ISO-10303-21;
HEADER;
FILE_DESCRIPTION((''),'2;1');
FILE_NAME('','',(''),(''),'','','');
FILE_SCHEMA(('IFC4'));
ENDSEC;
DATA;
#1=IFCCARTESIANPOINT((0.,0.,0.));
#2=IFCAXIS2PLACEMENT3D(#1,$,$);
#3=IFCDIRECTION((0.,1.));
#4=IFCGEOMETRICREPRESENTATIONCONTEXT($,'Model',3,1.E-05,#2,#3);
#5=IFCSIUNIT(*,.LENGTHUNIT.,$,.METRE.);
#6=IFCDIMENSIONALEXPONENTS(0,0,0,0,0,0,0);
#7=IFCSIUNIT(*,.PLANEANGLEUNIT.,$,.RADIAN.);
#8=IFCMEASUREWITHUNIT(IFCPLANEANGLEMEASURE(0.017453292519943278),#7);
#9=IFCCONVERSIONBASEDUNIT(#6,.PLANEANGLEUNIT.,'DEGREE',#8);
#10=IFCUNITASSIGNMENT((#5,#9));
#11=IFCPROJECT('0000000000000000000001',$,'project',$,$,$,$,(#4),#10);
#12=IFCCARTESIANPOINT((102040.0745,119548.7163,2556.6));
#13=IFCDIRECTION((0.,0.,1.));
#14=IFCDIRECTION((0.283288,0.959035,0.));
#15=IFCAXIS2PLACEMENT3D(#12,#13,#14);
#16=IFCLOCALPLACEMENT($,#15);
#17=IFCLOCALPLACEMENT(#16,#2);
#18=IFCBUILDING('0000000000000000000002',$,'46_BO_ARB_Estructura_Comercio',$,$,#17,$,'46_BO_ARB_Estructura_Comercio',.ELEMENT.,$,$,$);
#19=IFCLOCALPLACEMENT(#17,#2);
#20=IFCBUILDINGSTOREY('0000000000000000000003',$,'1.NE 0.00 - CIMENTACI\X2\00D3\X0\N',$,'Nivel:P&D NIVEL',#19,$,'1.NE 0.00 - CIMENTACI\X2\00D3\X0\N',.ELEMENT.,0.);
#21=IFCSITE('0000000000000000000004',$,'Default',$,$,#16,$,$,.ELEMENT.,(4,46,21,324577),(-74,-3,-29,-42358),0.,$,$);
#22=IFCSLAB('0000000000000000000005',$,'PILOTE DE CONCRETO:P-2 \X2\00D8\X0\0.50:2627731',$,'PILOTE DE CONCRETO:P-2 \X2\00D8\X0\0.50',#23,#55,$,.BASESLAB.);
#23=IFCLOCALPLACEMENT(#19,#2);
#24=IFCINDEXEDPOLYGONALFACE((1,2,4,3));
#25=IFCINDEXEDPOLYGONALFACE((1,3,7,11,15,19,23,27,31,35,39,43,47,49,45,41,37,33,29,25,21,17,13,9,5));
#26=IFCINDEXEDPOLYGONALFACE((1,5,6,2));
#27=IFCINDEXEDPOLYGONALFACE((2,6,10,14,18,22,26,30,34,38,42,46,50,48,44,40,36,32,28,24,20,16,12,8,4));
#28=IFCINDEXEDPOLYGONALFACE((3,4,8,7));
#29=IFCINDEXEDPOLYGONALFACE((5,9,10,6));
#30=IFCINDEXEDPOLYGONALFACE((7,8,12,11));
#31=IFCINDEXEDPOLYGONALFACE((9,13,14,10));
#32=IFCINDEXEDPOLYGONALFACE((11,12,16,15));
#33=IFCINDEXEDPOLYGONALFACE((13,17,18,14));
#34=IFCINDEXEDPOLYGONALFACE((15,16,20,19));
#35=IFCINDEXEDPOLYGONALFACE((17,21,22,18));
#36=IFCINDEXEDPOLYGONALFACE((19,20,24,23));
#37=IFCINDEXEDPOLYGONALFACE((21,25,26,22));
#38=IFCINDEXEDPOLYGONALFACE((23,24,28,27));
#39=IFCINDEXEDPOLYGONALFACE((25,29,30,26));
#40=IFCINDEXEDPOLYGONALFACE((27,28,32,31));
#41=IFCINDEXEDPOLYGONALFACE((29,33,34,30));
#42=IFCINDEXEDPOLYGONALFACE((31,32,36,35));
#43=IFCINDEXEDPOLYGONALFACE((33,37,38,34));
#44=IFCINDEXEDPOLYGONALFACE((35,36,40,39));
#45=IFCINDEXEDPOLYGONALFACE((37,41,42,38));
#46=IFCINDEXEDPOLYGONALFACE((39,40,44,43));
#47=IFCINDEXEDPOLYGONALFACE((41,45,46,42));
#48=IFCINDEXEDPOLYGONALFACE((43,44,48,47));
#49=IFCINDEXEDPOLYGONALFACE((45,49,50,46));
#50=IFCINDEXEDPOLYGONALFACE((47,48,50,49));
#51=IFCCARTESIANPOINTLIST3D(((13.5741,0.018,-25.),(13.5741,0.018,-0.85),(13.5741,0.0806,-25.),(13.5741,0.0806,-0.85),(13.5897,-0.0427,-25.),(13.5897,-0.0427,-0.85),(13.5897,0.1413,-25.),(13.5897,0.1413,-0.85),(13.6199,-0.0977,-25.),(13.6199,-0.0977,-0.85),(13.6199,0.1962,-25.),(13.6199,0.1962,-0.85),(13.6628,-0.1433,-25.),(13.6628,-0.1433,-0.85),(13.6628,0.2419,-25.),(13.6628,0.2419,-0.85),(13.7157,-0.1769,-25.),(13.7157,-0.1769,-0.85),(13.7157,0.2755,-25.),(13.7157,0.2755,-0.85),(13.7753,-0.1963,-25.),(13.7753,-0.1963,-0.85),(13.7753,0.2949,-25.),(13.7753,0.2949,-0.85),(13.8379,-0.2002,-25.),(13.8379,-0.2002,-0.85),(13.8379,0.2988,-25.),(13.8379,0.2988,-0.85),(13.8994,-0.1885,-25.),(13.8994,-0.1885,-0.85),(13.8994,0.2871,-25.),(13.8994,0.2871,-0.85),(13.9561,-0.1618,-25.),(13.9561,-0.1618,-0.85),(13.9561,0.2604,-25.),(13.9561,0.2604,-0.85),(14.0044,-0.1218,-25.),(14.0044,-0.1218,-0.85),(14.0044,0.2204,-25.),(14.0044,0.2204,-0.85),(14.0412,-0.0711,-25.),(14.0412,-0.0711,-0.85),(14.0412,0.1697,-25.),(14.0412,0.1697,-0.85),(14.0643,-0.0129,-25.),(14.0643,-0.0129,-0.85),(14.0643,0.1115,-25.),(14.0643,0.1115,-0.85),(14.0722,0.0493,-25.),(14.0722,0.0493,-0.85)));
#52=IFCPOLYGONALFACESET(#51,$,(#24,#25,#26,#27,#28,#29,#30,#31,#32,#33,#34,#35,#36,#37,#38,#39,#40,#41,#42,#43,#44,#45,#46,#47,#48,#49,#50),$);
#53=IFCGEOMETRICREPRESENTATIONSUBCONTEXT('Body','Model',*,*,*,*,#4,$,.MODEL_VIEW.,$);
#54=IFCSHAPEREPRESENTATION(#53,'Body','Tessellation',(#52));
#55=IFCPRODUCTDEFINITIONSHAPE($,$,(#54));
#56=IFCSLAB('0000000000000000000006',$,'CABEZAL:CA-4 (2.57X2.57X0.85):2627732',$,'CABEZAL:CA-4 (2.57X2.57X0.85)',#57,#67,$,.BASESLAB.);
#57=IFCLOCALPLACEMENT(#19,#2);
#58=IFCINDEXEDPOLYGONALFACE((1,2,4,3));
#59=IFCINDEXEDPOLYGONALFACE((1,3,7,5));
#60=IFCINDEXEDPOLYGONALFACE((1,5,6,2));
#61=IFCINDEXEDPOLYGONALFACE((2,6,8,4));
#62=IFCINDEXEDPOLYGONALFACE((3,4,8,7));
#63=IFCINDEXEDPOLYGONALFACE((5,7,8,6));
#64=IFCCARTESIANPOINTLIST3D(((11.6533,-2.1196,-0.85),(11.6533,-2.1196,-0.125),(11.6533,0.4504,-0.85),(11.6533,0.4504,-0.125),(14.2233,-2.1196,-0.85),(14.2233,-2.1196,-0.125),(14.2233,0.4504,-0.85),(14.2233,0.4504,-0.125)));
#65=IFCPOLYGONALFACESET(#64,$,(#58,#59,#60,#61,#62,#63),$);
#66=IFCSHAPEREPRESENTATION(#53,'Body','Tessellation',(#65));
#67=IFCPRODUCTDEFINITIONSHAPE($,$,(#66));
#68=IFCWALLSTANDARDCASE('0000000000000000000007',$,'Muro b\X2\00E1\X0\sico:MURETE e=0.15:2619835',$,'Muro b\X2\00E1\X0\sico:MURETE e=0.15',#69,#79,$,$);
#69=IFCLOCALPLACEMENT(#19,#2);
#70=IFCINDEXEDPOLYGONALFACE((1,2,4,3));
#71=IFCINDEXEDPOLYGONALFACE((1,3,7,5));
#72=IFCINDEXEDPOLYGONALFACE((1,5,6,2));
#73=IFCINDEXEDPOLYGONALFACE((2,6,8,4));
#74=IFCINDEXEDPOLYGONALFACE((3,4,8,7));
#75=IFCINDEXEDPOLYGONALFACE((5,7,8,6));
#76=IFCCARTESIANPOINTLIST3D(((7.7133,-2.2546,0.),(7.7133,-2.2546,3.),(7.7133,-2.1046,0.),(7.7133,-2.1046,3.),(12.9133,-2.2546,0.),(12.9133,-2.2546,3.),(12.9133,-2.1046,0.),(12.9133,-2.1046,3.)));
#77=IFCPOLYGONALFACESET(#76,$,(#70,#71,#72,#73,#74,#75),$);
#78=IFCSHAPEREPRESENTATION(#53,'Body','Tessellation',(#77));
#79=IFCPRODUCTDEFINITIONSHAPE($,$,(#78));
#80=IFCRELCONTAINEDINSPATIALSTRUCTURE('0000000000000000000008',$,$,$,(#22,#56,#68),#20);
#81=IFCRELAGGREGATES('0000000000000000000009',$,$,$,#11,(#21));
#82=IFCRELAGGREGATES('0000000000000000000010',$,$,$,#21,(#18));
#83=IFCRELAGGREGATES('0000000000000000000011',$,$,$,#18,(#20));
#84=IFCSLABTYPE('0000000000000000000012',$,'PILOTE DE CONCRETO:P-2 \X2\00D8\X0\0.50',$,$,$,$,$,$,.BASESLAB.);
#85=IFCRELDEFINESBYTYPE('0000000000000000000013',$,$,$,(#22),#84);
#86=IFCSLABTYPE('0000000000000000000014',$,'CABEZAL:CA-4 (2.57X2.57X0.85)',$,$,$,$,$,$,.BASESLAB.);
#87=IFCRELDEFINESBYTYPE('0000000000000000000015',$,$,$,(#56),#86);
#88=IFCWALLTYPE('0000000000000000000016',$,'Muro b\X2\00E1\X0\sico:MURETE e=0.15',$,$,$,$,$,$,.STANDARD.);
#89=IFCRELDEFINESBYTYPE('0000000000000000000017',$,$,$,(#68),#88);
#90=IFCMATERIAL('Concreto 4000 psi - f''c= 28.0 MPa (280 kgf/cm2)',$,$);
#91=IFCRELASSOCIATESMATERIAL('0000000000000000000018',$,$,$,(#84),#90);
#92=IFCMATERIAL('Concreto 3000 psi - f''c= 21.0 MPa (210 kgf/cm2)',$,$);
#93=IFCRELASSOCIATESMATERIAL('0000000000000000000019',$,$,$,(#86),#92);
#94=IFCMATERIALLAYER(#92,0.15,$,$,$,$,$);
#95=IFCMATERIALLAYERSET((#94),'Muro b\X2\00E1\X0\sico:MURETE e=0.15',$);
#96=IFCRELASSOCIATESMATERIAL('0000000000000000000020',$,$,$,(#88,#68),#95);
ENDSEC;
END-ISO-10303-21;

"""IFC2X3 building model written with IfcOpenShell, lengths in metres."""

from ifc_helpers import new_model, entity, si_unit, converted_unit, direction, frame, frame_2d, origin, place, context, subcontext, project, spatial, rectangle, circle, extrude, material, layer, layer_set, layer_usage, type_object, element, save


model = new_model("IFC2X3")

# Units and contexts
model_context = context("Model", 3, precision=1e-05, world=origin(), true_north=direction((0.0, 1.0)))
body_context = subcontext(model_context, "Body", "Model", "MODEL_VIEW")
ifc_project = project(units=[si_unit("LENGTHUNIT", "METRE"), converted_unit("PLANEANGLEUNIT", "DEGREE", entity("IfcPlaneAngleMeasure", 0.017453292519943278), si_unit("PLANEANGLEUNIT", "RADIAN"), dimensions=[0, 0, 0, 0, 0, 0, 0])], contexts=[model_context])

# Site, building, storey
site_placement = place(None, frame((102040.0745, 119548.7163, 2556.6), z_axis=(0.0, 0.0, 1.0), x_axis=(0.283288, 0.959035, 0.0)))
site = spatial("IfcSite", under=ifc_project, at=site_placement, Name="Default", CompositionType="ELEMENT", RefLatitude=(4, 46, 21, 324577), RefLongitude=(-74, -3, -29, -42358), RefElevation=0.0)
building_placement = place(site_placement, origin())
building = spatial("IfcBuilding", under=site, at=building_placement, Name="46_BO_ARB_Estructura_Comercio", LongName="46_BO_ARB_Estructura_Comercio", CompositionType="ELEMENT")
storey_placement = place(building_placement, origin())
storey = spatial("IfcBuildingStorey", under=building, at=storey_placement, Name="1.NE 0.00 - CIMENTACIÓN", ObjectType="Nivel:P&D NIVEL", LongName="1.NE 0.00 - CIMENTACIÓN", CompositionType="ELEMENT", Elevation=0.0)

# Shared definitions
ifc_material_1 = material(Name="Concreto 3000 psi - f'c= 21.0 MPa (210 kgf/cm2)")

# Slabs
ifc_material_2 = material(Name="Concreto 4000 psi - f'c= 28.0 MPa (280 kgf/cm2)")
slab_type_1 = type_object("IfcSlabType", Name="PILOTE DE CONCRETO:P-2 Ø0.50", PredefinedType="BASESLAB", material=ifc_material_2)
slab_1_placement = place(storey_placement, origin())
element("IfcSlab", 1, at=slab_1_placement, inside=storey, type_object=slab_type_1, Name="PILOTE DE CONCRETO:P-2 Ø0.50:2627731", ObjectType="PILOTE DE CONCRETO:P-2 Ø0.50", PredefinedType="BASESLAB", context=body_context, shape_type="SweptSolid", body=[
    extrude(circle(Radius=0.25, at=frame_2d((0.0, 0.0), x_axis=(1.0, 0.0))), frame((13.8222, 0.0493, -25.0)), (0.0, 0.0, 1.0), 24.15),
])
slab_type_2 = type_object("IfcSlabType", Name="CABEZAL:CA-4 (2.57X2.57X0.85)", PredefinedType="BASESLAB", material=ifc_material_1)
slab_2_placement = place(storey_placement, origin())
element("IfcSlab", 2, at=slab_2_placement, inside=storey, type_object=slab_type_2, Name="CABEZAL:CA-4 (2.57X2.57X0.85):2627732", ObjectType="CABEZAL:CA-4 (2.57X2.57X0.85)", PredefinedType="BASESLAB", context=body_context, shape_type="SweptSolid", body=[
    extrude(rectangle(XDim=2.57, YDim=2.57, at=frame_2d((0.0, 0.0), x_axis=(1.0, 0.0))), frame((12.9383, -0.8346, -0.85), z_axis=(0.0, 0.0, 1.0), x_axis=(-1.0, 0.0, 0.0)), (0.0, 0.0, 1.0), 0.725),
])

# Wall
ifc_layer_1 = layer(ifc_material_1, 0.15)
ifc_layer_set_1 = layer_set([ifc_layer_1], Name="Muro básico:MURETE e=0.15")
ifc_layer_usage_1 = layer_usage(ifc_layer_set_1, "AXIS2", "NEGATIVE", 0.075)
wall_type = type_object("IfcWallType", Name="Muro básico:MURETE e=0.15", PredefinedType="STANDARD", material=ifc_layer_set_1)
wall_placement = place(storey_placement, frame((7.7133, -2.1796, 0.0)))
element("IfcWallStandardCase", 3, at=wall_placement, inside=storey, type_object=wall_type, material=ifc_layer_usage_1, Name="Muro básico:MURETE e=0.15:2619835", ObjectType="Muro básico:MURETE e=0.15", context=body_context, shape_type="SweptSolid", body=[
    extrude(rectangle(XDim=5.2, YDim=0.15, at=frame_2d((2.6, 0.0), x_axis=(-1.0, 0.0))), origin(), (0.0, 0.0, 1.0), 3.0),
])

save(model, "model.ifc")
